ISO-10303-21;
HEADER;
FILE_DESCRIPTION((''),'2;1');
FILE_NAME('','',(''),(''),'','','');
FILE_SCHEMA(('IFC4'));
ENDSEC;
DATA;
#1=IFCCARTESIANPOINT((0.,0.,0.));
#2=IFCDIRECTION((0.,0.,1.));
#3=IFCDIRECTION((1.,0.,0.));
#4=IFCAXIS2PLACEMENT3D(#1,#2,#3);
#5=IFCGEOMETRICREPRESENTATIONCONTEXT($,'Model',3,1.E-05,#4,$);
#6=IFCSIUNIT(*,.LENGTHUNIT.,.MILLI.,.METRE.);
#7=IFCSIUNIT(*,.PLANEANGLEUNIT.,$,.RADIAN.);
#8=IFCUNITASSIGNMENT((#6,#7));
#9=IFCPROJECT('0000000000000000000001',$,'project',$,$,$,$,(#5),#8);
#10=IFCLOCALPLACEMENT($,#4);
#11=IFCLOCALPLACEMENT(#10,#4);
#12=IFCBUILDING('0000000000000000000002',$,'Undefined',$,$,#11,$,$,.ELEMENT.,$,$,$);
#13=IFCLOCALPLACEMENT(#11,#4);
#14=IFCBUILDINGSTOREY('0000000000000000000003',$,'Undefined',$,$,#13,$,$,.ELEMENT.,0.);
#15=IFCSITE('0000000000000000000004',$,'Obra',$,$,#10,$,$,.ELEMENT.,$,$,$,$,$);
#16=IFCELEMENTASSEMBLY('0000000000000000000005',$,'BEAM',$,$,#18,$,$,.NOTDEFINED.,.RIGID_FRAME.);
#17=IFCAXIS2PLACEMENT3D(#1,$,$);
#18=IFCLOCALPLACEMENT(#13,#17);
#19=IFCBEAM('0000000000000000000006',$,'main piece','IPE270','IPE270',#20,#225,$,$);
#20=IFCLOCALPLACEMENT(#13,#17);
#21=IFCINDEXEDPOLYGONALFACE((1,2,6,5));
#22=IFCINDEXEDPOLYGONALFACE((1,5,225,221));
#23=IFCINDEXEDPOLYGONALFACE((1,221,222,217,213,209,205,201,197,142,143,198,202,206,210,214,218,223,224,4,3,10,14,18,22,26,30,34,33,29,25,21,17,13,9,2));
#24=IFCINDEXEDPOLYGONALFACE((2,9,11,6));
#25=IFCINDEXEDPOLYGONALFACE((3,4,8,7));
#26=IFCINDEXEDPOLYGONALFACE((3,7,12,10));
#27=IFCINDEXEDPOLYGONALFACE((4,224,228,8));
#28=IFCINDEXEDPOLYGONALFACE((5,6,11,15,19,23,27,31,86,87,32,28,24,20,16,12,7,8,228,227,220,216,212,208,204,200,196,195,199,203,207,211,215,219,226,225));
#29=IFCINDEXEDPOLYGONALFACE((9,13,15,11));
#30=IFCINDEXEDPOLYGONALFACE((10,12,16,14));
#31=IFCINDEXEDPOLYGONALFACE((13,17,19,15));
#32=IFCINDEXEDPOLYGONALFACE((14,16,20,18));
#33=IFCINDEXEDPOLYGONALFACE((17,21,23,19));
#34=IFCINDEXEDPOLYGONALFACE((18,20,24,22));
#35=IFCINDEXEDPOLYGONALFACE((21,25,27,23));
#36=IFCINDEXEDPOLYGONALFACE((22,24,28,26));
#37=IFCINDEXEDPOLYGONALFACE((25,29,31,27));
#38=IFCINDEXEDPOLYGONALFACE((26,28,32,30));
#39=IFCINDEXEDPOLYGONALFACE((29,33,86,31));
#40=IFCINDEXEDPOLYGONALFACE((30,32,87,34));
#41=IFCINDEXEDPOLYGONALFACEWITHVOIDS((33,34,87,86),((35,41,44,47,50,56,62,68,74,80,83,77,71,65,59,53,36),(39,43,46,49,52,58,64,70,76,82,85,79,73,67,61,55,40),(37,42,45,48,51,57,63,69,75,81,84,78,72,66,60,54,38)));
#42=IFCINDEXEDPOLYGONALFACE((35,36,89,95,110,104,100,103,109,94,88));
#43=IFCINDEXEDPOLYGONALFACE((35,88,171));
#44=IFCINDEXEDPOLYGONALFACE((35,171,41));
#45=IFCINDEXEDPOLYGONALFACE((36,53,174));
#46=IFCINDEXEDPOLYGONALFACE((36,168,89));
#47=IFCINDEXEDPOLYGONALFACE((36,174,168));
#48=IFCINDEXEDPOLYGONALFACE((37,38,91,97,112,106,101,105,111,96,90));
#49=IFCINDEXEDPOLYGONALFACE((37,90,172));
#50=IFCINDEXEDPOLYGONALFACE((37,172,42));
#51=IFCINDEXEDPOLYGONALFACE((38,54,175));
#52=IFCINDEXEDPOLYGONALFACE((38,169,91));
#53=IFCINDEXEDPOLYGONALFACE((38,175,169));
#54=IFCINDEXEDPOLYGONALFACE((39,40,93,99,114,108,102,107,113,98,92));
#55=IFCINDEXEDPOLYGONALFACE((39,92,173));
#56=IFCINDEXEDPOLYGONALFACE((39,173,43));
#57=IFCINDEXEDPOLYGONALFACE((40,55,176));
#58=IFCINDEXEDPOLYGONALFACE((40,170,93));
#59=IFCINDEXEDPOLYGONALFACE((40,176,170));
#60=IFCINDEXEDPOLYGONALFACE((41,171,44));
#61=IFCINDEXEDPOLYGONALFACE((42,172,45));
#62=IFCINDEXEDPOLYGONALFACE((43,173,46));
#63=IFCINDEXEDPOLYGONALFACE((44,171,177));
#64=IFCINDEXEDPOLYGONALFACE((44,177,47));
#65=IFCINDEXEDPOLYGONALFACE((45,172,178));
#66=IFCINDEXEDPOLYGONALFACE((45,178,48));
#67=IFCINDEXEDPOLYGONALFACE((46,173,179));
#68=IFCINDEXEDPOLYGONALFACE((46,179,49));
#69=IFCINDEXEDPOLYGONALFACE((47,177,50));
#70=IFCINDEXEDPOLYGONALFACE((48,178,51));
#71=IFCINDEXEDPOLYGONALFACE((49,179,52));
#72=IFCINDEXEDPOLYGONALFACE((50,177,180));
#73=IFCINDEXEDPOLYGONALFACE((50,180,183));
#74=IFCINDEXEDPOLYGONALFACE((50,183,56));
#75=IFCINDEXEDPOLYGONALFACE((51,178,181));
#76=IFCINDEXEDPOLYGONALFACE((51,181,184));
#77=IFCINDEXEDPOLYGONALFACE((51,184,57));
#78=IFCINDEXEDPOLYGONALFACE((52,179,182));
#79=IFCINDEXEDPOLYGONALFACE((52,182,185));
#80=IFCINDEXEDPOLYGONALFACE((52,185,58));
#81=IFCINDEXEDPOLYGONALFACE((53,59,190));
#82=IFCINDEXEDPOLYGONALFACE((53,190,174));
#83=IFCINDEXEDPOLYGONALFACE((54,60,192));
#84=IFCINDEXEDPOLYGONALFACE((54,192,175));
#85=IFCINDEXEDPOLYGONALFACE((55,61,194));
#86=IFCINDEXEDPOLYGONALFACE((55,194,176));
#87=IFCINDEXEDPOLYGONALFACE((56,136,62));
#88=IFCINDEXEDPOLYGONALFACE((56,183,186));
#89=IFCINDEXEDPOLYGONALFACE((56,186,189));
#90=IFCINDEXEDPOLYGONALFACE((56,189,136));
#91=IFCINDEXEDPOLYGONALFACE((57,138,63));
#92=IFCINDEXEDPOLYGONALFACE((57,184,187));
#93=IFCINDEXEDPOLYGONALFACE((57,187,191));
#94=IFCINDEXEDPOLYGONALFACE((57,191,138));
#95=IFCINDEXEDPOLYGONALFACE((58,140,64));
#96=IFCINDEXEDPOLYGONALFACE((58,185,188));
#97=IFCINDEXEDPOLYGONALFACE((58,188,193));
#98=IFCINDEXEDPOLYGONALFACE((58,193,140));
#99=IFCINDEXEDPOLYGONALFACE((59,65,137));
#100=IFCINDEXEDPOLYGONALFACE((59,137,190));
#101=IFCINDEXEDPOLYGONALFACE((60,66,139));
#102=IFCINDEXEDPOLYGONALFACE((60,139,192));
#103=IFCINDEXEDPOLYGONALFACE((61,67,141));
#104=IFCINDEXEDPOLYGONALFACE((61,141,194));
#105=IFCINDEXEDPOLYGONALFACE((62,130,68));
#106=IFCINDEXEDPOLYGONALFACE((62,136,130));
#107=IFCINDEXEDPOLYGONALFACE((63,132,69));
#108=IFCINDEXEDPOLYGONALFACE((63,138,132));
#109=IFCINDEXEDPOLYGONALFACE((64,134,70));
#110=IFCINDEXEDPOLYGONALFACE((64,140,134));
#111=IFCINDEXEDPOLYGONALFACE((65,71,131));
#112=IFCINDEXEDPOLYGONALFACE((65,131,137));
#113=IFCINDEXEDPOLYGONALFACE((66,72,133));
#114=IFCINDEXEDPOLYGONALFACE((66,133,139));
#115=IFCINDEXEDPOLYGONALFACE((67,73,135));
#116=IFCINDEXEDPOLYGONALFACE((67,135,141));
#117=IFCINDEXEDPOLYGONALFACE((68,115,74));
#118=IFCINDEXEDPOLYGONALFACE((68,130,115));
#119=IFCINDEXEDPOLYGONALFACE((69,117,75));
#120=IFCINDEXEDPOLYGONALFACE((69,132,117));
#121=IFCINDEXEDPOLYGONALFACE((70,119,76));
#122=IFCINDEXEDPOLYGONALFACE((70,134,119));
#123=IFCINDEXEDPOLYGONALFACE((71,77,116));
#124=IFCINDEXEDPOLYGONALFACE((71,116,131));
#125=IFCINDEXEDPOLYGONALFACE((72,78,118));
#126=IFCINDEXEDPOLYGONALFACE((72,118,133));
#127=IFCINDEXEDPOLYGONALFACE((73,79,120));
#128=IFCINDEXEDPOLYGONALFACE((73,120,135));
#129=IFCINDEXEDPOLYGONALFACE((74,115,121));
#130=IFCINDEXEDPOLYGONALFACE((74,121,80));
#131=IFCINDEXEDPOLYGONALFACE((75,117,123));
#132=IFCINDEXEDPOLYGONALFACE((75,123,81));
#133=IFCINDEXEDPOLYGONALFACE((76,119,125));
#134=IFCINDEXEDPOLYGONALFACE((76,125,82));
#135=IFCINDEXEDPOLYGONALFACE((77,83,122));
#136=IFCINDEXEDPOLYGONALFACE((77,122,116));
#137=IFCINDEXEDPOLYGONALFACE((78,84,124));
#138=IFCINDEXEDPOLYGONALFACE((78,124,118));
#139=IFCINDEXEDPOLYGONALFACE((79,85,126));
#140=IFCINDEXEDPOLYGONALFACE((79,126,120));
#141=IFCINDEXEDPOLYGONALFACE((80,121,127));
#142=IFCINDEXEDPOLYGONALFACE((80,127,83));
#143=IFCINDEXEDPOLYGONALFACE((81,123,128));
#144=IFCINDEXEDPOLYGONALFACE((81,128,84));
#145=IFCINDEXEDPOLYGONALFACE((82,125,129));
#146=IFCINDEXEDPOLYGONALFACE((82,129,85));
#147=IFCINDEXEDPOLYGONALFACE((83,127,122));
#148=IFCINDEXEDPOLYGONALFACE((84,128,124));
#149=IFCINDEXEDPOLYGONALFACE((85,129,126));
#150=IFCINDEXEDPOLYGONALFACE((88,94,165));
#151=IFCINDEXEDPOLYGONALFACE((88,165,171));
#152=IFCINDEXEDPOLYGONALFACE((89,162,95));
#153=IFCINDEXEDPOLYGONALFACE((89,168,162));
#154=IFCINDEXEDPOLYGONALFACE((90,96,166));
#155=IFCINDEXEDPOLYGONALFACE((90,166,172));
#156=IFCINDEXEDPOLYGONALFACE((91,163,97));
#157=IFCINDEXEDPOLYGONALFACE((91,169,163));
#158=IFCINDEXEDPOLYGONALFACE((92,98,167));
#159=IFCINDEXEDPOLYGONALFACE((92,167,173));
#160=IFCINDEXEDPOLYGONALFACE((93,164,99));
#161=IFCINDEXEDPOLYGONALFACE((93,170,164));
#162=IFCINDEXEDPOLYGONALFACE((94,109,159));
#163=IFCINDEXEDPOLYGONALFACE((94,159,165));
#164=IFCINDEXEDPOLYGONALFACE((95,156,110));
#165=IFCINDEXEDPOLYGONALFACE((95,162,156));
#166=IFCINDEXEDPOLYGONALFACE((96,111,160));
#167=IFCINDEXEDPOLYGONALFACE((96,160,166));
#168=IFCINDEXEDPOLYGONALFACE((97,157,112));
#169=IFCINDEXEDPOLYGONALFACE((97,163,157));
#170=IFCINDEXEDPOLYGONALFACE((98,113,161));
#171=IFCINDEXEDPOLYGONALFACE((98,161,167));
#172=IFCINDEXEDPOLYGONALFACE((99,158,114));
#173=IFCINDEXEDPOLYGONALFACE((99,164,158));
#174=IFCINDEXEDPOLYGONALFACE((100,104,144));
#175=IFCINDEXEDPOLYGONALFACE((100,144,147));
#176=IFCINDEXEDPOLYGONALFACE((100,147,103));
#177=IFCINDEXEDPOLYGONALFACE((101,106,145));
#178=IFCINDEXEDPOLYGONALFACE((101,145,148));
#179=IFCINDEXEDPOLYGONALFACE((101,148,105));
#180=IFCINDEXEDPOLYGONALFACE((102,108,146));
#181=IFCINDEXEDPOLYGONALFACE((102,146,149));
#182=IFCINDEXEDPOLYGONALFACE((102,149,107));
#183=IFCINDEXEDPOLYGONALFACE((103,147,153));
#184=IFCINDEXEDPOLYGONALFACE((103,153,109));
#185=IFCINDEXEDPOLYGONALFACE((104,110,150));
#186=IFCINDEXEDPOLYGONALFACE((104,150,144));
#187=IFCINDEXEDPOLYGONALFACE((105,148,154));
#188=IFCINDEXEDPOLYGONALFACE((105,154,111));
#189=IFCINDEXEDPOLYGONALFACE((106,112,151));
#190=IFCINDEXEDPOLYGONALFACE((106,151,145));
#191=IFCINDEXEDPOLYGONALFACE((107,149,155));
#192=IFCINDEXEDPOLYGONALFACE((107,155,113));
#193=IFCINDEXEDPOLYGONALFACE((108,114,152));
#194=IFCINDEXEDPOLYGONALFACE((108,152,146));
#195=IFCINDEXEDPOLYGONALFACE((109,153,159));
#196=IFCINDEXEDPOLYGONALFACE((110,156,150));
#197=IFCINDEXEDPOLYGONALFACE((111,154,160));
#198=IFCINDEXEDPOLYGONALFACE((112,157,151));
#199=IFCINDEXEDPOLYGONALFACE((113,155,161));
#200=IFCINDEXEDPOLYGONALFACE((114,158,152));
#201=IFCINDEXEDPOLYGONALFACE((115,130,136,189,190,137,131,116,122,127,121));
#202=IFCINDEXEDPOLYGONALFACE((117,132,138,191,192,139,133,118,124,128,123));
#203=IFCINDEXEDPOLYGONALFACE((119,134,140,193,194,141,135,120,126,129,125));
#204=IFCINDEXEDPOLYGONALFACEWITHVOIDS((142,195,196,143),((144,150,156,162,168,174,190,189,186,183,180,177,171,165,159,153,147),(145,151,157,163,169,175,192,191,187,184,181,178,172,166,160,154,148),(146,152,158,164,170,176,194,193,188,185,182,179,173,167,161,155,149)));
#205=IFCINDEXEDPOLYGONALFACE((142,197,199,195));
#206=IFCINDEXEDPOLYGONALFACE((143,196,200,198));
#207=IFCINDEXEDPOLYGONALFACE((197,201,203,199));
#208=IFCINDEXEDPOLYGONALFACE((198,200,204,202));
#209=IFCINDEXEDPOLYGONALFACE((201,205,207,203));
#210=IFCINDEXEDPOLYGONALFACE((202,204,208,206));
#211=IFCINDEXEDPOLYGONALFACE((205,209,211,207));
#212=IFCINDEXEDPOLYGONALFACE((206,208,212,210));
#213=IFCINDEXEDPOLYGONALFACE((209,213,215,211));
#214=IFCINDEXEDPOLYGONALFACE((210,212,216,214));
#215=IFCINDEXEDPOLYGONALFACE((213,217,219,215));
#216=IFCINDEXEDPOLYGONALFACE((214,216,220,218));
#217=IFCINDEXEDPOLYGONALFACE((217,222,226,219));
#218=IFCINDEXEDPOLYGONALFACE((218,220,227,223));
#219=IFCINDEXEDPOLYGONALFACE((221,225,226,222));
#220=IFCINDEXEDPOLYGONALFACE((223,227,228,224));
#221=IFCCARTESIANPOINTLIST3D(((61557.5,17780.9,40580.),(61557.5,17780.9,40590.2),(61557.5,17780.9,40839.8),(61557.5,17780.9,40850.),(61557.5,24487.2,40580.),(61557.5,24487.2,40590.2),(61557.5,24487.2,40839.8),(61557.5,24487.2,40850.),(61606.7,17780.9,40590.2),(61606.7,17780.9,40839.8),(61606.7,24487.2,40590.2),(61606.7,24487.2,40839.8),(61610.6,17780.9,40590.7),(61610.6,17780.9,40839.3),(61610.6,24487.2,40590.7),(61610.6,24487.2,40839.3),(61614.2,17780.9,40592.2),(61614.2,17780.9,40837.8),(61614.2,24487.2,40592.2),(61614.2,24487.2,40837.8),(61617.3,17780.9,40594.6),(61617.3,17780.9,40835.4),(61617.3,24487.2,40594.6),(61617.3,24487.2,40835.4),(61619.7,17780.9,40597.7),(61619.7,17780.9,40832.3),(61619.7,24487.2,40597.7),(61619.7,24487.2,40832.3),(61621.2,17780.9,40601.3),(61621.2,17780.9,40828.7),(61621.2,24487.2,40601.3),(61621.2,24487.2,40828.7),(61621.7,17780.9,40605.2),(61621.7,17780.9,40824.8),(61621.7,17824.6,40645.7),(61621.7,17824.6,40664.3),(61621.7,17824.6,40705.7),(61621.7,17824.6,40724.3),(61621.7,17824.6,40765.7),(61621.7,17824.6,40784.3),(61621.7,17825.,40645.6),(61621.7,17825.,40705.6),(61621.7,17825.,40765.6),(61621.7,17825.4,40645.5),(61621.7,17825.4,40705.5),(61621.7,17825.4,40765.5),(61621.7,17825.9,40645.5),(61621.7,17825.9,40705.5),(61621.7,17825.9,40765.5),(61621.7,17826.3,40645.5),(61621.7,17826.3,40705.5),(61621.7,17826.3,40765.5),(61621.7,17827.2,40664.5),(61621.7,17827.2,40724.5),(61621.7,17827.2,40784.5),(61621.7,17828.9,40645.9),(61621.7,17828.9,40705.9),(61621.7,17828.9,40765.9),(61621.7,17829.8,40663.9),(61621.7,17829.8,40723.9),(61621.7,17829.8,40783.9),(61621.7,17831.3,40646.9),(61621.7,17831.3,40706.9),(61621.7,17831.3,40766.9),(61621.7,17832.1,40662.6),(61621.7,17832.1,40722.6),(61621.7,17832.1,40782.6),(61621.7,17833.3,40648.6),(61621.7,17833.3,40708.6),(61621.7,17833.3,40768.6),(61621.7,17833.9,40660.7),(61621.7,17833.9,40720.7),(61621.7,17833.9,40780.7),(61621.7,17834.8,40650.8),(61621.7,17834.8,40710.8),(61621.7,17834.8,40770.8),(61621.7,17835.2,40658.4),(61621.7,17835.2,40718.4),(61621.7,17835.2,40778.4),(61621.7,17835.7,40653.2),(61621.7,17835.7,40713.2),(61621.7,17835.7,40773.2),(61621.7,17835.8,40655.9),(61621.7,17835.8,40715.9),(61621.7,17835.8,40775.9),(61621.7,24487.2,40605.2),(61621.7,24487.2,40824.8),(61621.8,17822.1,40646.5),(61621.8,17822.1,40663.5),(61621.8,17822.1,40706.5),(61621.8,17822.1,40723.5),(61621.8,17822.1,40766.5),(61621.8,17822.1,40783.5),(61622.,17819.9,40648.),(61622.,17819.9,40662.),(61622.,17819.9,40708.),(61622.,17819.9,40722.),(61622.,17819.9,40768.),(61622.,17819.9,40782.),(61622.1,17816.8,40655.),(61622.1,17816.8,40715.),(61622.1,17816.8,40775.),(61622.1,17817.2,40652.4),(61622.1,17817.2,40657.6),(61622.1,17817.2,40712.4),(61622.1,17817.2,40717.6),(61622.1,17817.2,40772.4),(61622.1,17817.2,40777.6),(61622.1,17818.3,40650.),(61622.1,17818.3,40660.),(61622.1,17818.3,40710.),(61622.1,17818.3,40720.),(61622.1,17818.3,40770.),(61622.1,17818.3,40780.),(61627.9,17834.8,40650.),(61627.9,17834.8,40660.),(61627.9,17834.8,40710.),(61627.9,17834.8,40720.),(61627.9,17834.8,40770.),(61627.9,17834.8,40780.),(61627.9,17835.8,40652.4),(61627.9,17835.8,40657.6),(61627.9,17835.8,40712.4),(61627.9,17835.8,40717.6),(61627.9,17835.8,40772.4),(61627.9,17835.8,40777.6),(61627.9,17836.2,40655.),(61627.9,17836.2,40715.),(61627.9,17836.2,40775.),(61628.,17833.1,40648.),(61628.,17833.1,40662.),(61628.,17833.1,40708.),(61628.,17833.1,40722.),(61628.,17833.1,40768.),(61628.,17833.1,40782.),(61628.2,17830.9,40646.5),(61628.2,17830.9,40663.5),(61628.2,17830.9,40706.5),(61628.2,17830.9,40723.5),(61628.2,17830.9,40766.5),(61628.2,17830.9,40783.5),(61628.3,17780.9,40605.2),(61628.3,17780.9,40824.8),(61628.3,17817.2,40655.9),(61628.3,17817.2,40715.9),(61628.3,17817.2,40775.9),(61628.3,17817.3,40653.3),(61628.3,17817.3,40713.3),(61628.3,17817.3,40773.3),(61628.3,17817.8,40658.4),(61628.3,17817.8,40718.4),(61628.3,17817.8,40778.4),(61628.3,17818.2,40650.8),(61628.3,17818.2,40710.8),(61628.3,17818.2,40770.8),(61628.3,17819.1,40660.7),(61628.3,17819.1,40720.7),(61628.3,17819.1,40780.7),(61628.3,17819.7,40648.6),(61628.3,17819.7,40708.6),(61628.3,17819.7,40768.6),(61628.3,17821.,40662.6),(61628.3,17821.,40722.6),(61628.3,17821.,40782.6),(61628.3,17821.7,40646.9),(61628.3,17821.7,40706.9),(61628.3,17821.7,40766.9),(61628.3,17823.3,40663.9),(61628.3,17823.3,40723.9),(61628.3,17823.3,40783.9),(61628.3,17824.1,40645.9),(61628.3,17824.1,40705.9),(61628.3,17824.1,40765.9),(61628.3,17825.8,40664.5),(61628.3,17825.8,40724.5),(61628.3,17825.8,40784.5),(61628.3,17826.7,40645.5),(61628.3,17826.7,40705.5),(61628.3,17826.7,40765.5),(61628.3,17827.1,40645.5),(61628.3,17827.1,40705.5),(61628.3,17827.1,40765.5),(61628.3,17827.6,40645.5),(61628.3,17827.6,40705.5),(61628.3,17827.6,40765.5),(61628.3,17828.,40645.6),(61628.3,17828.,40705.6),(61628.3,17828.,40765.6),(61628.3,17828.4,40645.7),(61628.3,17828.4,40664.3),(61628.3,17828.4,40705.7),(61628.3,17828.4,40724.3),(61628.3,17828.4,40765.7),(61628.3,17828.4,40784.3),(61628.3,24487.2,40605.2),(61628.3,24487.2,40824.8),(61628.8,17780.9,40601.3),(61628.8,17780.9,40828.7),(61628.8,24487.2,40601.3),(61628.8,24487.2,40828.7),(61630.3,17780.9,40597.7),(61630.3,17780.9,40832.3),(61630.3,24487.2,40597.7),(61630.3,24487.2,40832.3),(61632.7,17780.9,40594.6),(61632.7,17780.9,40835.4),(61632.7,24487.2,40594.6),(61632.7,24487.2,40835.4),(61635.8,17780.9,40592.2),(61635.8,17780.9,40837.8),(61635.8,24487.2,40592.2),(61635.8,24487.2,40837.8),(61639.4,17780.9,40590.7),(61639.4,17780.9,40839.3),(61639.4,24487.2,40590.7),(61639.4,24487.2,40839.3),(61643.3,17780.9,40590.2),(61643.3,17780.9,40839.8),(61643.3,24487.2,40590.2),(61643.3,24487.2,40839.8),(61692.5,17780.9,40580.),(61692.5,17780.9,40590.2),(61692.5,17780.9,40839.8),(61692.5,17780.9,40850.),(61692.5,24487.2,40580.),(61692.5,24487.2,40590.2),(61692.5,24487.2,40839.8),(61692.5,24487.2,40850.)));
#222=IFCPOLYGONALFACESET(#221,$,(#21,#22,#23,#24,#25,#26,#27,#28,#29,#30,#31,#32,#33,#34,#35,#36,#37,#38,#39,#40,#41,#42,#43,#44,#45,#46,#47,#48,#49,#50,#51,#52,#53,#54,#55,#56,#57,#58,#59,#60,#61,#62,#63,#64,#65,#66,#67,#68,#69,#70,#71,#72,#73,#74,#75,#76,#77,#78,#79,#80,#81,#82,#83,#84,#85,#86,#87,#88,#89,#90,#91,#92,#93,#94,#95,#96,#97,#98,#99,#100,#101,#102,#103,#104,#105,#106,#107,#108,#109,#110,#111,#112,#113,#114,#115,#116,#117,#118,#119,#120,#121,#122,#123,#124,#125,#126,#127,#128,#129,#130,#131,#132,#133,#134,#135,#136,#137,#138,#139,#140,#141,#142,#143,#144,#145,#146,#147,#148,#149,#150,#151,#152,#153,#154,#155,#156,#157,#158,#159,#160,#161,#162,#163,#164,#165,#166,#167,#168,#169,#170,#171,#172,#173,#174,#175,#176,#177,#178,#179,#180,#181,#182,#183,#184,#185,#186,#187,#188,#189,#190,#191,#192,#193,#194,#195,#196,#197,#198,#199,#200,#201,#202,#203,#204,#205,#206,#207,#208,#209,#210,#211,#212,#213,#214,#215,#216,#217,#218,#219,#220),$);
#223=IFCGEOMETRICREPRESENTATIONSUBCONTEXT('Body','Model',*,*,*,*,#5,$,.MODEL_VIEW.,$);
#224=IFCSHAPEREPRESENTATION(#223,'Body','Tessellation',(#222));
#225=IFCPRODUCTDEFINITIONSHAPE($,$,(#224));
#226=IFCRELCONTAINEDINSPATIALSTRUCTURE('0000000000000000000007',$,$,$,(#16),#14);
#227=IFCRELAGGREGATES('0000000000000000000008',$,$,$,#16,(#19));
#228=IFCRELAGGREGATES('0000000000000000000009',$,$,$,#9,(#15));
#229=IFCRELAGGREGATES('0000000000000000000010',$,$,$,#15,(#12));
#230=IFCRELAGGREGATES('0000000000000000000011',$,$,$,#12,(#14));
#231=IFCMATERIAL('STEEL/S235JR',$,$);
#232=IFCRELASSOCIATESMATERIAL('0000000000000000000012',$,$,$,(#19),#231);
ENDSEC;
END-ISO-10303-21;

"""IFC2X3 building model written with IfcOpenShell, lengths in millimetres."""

from ifc_helpers import new_model, si_unit, frame, origin_with_axes, origin_2d_with_axis, place, context, subcontext, project, spatial, circle, i_section, extrude, clip, halfspace, source, transform, mapped, material, element, aggregate, save


model = new_model("IFC2X3")

# Units and contexts
model_context = context("Model", 3, precision=1e-05, world=origin_with_axes())
body_context = subcontext(model_context, "Body", "Model", "MODEL_VIEW")
ifc_project = project(units=[si_unit("LENGTHUNIT", "METRE", prefix="MILLI"), si_unit("PLANEANGLEUNIT", "RADIAN")], contexts=[model_context])

# Site, building, storey
site_placement = place(None, origin_with_axes())
site = spatial("IfcSite", under=ifc_project, at=site_placement, Name="Obra", CompositionType="ELEMENT")
building_placement = place(site_placement, origin_with_axes())
building = spatial("IfcBuilding", under=site, at=building_placement, Name="Undefined", CompositionType="ELEMENT")
storey_placement = place(building_placement, origin_with_axes())
storey = spatial("IfcBuildingStorey", under=building, at=storey_placement, Name="Undefined", CompositionType="ELEMENT", Elevation=0.0)

# Shared definitions
ifc_material_1 = material(Name="STEEL/S235JR")

# Element assembly, beam, opening
assembly_1_placement = place(storey_placement, origin_with_axes())
assembly_1 = element("IfcElementAssembly", 1, at=assembly_1_placement, inside=storey, Name="BEAM", AssemblyPlace="NOTDEFINED", PredefinedType="RIGID_FRAME")
beam_1_placement = place(assembly_1_placement, frame((61625.0, 24487.2, 40715.0), z_axis=(0.0, 0.0, 1.0), x_axis=(0.0, -1.0, 0.0)))
beam_1 = element("IfcBeam", 2, at=beam_1_placement, material=ifc_material_1, Name="main piece", Description="IPE270", ObjectType="IPE270", context=body_context, shape_type="Clipping", body=[
    clip(extrude(i_section(OverallWidth=135.0, OverallDepth=270.0, WebThickness=6.6, FlangeThickness=10.2, FilletRadius=15.0, at=origin_2d_with_axis()), frame((6706.3, 0.0, 0.0), z_axis=(-1.0, 0.0, 0.0), x_axis=(0.0, -1.0, 0.0)), (0.0, 0.0, 1.0), 6706.3), halfspace(frame((6715.4, -89.1, -120.0), z_axis=(0.998367, 0.057126, 0.0), x_axis=(0.0, 0.0, 1.0)), False)),
])
shared_shape_1 = source(origin_with_axes(), body_context, "Body", "SweptSolid", [
    extrude(circle(Radius=9.5, at=origin_2d_with_axis()), frame((0.0, -35.4, 0.0), z_axis=(0.0, 1.0, 0.0), x_axis=(1.0, 0.0, 0.0)), (0.0, 0.0, 1.0), 6.8),
])
opening_1_placement = place(assembly_1_placement, frame((61595.9, 17774.8, 40835.0), z_axis=(-0.057107, 0.998368, 0.0), x_axis=(0.0, 0.0, -1.0)))
element("IfcOpeningElement", 3, at=opening_1_placement, cuts=beam_1, ObjectType="Opening", context=body_context, shape_type="MappedRepresentation", body=[
    mapped(shared_shape_1, transform((60.0, 0.0, 50.0))),
    mapped(shared_shape_1, transform((120.0, 0.0, 50.0))),
    mapped(shared_shape_1, transform((180.0, 0.0, 50.0))),
])

aggregate(assembly_1, [beam_1])

save(model, "model.ifc")
